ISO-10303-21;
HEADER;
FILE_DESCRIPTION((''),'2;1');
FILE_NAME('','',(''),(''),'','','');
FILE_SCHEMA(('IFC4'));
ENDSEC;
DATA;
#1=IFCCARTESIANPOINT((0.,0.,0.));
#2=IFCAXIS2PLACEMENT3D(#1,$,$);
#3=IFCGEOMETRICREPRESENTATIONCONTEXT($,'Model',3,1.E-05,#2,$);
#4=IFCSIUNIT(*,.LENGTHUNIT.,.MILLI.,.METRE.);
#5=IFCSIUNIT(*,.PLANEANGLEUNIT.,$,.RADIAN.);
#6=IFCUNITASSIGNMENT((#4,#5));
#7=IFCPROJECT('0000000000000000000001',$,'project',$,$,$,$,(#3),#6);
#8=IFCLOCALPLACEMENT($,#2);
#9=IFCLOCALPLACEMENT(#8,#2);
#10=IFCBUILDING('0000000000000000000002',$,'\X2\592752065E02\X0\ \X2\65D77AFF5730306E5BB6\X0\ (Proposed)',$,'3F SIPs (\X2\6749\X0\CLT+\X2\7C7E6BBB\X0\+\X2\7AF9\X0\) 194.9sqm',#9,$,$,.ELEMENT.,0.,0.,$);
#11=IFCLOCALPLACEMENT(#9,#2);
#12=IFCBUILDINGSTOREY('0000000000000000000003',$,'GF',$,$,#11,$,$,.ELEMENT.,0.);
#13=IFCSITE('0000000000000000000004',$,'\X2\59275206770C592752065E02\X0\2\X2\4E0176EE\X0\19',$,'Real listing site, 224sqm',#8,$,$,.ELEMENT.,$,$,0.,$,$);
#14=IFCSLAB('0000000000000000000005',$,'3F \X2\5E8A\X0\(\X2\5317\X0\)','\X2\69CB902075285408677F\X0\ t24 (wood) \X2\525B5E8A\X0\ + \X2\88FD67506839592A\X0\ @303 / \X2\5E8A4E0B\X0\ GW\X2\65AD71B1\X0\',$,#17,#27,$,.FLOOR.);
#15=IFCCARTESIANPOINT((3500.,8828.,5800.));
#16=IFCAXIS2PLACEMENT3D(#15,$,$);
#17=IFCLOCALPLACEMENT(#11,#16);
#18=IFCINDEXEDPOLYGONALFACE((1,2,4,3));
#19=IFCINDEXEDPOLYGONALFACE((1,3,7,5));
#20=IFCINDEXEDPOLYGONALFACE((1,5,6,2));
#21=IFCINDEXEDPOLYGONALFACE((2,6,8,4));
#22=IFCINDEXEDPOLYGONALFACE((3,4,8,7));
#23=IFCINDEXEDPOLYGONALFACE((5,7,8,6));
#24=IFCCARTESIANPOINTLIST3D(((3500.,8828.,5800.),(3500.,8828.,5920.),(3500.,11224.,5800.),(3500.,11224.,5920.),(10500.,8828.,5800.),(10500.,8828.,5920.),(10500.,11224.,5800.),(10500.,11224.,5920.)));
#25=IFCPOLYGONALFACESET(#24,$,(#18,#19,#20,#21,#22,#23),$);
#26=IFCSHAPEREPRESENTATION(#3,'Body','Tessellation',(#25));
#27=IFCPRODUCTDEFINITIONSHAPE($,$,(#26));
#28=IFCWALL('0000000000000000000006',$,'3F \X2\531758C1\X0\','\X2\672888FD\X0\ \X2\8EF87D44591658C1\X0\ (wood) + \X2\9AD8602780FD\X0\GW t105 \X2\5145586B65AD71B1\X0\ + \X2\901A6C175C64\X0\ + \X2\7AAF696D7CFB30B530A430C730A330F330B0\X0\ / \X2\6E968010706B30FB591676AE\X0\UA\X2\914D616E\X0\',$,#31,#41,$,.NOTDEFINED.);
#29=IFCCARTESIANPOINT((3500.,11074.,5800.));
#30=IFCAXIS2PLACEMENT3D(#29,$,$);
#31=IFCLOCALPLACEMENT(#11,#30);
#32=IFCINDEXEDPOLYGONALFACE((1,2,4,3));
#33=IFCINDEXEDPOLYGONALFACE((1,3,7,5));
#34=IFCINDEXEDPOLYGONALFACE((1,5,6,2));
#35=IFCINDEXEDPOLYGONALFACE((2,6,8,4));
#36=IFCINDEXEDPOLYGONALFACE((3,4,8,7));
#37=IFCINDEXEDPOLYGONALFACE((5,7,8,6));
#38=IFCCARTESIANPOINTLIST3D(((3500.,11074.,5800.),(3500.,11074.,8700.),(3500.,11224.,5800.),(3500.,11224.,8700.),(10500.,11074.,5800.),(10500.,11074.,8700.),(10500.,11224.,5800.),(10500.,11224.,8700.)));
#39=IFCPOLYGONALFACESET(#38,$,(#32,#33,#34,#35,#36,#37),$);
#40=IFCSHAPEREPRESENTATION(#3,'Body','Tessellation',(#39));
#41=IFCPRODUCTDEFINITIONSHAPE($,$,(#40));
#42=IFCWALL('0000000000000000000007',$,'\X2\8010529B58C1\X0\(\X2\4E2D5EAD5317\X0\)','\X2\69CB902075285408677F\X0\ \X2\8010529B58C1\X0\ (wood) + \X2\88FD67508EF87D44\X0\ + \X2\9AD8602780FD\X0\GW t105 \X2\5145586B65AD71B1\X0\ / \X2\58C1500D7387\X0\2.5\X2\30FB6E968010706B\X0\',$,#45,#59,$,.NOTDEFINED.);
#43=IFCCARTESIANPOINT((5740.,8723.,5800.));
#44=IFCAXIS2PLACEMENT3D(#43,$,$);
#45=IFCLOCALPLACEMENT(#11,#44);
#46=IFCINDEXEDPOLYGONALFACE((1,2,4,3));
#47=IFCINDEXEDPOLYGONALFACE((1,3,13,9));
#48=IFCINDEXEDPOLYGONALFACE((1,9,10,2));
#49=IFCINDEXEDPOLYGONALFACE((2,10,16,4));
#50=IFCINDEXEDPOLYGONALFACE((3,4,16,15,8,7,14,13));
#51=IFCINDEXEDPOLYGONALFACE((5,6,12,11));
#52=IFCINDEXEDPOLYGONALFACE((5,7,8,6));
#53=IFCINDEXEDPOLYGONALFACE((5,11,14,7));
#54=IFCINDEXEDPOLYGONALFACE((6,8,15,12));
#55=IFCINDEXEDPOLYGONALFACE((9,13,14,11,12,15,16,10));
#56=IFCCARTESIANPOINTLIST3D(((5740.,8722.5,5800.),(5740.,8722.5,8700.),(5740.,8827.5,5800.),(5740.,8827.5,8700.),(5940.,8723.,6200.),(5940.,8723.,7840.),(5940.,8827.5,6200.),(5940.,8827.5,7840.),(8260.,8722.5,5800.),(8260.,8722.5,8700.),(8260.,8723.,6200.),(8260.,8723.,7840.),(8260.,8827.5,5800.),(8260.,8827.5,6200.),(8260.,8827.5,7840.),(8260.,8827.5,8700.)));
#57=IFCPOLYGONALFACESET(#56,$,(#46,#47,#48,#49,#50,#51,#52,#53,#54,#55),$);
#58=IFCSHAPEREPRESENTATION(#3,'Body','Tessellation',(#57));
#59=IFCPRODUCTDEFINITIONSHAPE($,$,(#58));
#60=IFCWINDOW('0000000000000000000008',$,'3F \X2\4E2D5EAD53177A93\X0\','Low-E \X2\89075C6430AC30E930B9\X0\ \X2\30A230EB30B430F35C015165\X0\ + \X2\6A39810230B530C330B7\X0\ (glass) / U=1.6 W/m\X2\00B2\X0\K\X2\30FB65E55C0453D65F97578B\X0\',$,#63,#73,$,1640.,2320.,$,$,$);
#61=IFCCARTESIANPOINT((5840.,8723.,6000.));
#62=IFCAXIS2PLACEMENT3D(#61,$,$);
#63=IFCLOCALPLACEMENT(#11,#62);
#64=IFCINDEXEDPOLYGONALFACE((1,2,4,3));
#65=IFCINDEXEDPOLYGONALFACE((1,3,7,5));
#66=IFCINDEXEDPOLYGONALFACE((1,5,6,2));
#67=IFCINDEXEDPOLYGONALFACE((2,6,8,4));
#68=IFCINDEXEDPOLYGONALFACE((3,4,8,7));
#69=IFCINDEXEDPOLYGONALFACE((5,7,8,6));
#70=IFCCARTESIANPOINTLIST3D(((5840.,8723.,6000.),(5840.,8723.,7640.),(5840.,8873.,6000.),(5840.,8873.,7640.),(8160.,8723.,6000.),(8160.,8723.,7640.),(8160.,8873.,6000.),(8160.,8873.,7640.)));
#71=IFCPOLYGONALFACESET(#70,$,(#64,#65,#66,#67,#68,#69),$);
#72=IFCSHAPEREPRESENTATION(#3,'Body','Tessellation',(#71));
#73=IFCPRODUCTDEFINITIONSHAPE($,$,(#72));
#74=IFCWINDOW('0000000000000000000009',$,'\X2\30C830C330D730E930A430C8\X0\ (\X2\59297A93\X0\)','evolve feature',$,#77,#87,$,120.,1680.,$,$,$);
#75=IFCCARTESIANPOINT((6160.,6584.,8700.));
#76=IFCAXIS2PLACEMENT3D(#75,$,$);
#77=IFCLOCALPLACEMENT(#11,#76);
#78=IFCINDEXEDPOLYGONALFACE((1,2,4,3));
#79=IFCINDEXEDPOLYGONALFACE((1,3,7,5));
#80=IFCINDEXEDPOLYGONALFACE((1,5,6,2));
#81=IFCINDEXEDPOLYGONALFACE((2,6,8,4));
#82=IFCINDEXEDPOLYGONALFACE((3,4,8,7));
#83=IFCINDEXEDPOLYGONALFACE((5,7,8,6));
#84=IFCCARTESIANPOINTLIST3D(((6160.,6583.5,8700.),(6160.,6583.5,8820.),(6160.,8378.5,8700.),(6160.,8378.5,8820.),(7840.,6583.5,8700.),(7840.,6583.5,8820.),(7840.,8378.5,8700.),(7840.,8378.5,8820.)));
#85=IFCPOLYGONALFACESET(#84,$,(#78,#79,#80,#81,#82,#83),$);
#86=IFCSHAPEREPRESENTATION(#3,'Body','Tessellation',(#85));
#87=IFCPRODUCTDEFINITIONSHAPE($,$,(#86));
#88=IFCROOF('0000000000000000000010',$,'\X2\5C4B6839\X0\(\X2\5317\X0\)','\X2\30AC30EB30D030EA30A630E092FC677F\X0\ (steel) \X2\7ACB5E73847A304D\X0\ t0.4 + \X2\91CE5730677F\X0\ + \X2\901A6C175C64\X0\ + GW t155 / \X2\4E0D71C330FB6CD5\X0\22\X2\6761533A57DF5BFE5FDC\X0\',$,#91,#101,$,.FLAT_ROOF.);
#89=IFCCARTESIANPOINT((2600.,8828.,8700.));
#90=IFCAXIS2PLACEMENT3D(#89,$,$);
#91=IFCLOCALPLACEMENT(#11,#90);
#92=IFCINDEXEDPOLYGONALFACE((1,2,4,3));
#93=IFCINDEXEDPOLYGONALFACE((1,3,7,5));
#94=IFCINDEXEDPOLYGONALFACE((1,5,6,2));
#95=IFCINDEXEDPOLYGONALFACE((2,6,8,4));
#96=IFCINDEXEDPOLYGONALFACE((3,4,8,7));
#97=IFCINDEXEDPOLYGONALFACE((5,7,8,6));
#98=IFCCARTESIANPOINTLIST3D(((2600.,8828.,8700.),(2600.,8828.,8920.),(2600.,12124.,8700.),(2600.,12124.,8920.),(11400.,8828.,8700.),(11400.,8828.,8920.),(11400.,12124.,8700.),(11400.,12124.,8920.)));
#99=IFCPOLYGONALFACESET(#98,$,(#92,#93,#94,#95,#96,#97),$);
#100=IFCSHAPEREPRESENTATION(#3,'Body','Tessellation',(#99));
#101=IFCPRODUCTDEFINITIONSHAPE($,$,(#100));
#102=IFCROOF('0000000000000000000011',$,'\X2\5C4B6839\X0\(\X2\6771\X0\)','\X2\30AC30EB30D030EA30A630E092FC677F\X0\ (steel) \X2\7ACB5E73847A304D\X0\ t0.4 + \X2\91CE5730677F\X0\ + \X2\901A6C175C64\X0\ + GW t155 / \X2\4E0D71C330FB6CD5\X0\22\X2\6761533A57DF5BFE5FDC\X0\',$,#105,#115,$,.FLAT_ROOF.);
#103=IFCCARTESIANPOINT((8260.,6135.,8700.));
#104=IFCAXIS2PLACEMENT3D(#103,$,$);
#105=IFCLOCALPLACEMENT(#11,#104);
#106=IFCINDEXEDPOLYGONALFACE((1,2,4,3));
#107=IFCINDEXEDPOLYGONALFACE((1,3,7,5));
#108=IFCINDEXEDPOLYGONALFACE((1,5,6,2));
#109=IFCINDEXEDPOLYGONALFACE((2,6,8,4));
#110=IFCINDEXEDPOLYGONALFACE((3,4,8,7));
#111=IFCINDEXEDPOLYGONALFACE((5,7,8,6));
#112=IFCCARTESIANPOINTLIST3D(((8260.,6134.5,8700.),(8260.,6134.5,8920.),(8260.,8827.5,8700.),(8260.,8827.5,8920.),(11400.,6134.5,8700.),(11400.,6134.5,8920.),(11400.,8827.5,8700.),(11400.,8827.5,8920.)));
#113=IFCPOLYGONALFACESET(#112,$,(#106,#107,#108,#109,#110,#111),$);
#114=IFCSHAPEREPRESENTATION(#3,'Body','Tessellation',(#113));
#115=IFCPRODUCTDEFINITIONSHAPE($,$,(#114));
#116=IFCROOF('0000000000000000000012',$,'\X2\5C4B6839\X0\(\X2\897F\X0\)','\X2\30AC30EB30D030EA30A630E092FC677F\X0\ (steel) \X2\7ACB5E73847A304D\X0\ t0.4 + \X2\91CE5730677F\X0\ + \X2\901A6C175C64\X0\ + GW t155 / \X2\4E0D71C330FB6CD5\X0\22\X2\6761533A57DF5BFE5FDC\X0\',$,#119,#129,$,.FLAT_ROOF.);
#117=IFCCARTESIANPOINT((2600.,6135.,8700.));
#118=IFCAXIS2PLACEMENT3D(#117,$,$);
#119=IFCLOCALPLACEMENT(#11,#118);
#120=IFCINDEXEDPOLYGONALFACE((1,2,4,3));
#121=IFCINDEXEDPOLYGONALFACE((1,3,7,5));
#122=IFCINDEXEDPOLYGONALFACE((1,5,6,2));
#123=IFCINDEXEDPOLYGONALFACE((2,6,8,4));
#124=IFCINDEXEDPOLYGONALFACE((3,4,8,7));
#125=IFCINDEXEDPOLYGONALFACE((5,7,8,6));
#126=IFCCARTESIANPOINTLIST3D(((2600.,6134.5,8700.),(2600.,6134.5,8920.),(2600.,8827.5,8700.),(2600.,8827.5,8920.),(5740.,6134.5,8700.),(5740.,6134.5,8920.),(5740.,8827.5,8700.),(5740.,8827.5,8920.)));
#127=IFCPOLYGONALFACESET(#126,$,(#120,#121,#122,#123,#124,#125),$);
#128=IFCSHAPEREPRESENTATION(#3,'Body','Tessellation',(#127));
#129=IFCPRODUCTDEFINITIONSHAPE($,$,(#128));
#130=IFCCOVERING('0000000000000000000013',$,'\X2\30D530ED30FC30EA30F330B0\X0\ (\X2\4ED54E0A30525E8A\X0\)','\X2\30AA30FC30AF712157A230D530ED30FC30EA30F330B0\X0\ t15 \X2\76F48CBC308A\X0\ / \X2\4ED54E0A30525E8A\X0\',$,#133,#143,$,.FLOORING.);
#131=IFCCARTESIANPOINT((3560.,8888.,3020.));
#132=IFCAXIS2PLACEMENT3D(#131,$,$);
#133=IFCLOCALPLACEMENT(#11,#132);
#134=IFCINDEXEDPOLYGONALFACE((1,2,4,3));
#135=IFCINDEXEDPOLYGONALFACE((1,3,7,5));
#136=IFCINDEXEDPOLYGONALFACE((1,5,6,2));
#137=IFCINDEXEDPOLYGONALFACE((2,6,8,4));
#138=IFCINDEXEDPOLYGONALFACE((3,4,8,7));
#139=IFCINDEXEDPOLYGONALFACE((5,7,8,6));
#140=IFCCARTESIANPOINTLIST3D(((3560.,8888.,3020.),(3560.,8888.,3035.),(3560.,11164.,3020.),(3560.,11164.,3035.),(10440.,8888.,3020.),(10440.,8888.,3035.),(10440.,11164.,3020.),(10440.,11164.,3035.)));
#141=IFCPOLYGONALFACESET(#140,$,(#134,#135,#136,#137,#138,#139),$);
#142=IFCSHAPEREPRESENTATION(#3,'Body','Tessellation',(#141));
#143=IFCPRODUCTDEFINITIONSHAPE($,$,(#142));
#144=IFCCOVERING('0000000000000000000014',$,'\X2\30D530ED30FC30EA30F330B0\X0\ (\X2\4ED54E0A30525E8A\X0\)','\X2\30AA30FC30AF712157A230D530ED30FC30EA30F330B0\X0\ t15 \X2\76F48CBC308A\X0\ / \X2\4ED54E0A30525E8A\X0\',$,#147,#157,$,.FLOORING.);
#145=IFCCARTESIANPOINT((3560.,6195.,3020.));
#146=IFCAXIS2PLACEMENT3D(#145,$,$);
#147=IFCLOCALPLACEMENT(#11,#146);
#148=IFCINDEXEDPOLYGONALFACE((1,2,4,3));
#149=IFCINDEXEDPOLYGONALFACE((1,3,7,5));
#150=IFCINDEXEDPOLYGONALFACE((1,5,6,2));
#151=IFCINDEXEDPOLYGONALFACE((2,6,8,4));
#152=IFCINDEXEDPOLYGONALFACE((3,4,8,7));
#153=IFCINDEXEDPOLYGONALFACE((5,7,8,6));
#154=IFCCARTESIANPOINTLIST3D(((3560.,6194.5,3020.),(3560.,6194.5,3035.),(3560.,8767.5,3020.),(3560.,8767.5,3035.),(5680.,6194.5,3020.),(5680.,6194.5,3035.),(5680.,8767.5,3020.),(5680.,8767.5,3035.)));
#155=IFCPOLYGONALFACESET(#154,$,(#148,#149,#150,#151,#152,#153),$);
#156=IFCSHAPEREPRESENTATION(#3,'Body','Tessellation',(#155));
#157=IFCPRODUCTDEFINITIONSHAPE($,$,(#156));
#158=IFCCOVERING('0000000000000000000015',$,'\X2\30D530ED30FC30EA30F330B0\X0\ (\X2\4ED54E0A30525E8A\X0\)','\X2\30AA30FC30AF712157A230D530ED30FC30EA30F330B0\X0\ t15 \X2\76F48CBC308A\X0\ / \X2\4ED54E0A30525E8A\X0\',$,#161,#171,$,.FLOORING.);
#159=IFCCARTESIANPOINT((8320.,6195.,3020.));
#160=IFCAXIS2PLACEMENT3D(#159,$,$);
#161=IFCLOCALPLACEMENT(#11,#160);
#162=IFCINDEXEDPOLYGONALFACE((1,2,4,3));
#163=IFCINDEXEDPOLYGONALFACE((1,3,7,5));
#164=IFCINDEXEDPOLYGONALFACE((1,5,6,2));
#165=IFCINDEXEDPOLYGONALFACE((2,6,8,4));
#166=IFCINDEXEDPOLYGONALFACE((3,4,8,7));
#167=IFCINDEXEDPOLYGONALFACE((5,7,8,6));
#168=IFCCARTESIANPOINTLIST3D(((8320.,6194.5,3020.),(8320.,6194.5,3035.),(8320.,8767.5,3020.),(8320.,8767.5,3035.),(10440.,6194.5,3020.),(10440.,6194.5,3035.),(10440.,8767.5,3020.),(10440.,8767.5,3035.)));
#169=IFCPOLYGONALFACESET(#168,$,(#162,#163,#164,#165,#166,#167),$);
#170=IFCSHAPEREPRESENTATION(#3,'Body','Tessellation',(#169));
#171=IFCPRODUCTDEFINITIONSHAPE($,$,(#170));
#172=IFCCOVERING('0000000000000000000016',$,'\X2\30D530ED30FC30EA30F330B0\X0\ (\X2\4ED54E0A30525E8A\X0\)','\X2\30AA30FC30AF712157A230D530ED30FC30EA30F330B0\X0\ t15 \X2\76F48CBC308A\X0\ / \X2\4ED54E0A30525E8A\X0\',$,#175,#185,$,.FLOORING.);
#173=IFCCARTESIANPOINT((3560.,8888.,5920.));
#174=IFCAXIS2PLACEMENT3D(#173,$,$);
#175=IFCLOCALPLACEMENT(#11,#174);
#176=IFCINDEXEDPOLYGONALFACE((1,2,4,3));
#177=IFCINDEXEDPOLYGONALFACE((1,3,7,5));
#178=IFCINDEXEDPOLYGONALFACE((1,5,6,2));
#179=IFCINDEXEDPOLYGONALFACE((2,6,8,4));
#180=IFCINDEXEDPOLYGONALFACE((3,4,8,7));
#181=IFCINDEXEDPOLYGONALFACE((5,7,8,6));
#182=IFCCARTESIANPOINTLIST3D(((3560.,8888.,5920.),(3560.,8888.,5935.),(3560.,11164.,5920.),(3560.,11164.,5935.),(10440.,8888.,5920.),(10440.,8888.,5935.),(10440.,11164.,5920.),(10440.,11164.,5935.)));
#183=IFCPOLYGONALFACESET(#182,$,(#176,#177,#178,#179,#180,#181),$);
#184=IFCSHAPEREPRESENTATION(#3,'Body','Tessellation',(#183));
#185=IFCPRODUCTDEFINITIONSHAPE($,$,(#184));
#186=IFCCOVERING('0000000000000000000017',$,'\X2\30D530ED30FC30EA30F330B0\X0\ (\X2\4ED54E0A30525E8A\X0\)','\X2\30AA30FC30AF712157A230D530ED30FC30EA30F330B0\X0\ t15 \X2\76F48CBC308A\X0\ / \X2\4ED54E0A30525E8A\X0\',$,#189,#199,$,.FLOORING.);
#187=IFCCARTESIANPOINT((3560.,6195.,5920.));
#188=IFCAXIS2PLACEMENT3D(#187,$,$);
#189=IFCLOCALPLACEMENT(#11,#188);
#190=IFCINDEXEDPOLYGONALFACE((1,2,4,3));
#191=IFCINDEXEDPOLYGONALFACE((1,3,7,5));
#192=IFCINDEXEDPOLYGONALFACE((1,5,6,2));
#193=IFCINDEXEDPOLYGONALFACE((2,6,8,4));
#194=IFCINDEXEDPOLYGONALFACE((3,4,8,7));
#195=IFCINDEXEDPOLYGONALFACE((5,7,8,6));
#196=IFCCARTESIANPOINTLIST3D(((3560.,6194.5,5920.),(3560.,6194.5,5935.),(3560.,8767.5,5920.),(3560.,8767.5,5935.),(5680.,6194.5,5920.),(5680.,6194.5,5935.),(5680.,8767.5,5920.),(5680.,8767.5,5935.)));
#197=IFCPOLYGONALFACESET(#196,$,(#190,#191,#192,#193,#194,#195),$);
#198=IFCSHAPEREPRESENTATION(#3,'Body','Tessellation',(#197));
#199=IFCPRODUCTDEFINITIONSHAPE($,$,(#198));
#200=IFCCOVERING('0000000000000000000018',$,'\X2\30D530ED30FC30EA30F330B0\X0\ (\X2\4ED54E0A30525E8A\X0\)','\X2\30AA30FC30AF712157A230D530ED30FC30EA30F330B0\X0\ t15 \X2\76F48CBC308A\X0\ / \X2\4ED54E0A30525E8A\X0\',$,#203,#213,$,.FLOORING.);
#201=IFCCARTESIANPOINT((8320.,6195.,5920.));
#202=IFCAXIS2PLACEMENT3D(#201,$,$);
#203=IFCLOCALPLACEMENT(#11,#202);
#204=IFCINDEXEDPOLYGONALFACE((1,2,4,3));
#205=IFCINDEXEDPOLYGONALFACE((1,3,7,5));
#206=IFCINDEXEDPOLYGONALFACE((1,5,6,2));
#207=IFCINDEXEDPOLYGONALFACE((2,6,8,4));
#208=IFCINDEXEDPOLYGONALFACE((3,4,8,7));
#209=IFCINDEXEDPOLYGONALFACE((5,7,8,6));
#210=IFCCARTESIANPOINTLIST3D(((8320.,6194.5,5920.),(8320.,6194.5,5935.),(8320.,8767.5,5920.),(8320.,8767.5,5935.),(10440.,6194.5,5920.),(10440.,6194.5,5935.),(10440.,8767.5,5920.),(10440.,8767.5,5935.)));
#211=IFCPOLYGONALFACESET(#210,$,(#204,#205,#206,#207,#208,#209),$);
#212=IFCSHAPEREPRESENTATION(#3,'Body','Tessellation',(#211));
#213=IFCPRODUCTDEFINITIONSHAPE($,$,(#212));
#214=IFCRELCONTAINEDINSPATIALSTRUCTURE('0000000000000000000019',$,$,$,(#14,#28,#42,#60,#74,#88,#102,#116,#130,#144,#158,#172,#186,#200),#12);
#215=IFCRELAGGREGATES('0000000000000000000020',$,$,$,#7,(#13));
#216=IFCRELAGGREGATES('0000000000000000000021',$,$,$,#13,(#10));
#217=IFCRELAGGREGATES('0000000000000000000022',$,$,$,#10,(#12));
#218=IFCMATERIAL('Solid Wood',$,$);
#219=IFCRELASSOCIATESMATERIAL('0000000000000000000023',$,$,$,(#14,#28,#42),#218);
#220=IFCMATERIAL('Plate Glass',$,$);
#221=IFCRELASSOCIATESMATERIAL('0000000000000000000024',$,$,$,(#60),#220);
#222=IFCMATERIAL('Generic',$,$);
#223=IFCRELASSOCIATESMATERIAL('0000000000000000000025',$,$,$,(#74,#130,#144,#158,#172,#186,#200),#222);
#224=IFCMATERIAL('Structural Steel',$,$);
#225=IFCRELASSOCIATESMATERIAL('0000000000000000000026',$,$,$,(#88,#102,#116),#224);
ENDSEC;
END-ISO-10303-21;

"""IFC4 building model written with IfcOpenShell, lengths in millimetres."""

from ifc_helpers import new_model, si_unit, frame, frame_2d, origin, place, context, project, spatial, rectangle, extrude, material, element, fill, save


model = new_model("IFC4")

# Units and contexts
model_context = context("Model", 3, precision=1e-05, world=origin())
ifc_project = project(units=[si_unit("LENGTHUNIT", "METRE", prefix="MILLI"), si_unit("PLANEANGLEUNIT", "RADIAN")], contexts=[model_context])

# Site, building, storey
site_placement = place(None, origin())
site = spatial("IfcSite", under=ifc_project, at=site_placement, Name="大分県大分市2丁目19", ObjectType="Real listing site, 224sqm", CompositionType="ELEMENT", RefElevation=0.0)
building_placement = place(site_placement, origin())
building = spatial("IfcBuilding", under=site, at=building_placement, Name="大分市 旗竿地の家 (Proposed)", ObjectType="3F SIPs (杉CLT+籾殻+竹) 194.9sqm", CompositionType="ELEMENT", ElevationOfRefHeight=0.0, ElevationOfTerrain=0.0)
storey_placement = place(building_placement, origin())
storey = spatial("IfcBuildingStorey", under=building, at=storey_placement, Name="GF", CompositionType="ELEMENT", Elevation=0.0)

# Slab
ifc_material_1 = material(Name="Solid Wood")
slab_placement = place(storey_placement, frame((3500.0, 8828.0, 5800.0)))
element("IfcSlab", 1, at=slab_placement, inside=storey, material=ifc_material_1, Name="3F 床(北)", Description="構造用合板 t24 (wood) 剛床 + 製材根太 @303 / 床下 GW断熱", PredefinedType="FLOOR", context=model_context, shape_type="SweptSolid", body=[
    extrude(rectangle(XDim=7000.0, YDim=2396.0, at=frame_2d((3500.0, 1198.0))), frame((3500.0, 8828.0, 5800.0)), (0.0, 0.0, 1.0), 120.0),
])

# Wall
wall_1_placement = place(storey_placement, frame((3500.0, 11074.0, 5800.0)))
element("IfcWall", 2, at=wall_1_placement, inside=storey, material=ifc_material_1, Name="3F 北壁", Description="木製 軸組外壁 (wood) + 高性能GW t105 充填断熱 + 通気層 + 窯業系サイディング / 準耐火・外皮UA配慮", PredefinedType="NOTDEFINED", context=model_context, shape_type="SweptSolid", body=[
    extrude(rectangle(XDim=7000.0, YDim=150.0, at=frame_2d((3500.0, 75.0))), frame((3500.0, 11074.0, 5800.0)), (0.0, 0.0, 1.0), 2900.0),
])

# Wall, opening, window
wall_2_placement = place(storey_placement, frame((5740.0, 8723.0, 5800.0)))
wall_2 = element("IfcWall", 3, at=wall_2_placement, inside=storey, material=ifc_material_1, Name="耐力壁(中庭北)", Description="構造用合板 耐力壁 (wood) + 製材軸組 + 高性能GW t105 充填断熱 / 壁倍率2.5・準耐火", PredefinedType="NOTDEFINED", context=model_context, shape_type="SweptSolid", body=[
    extrude(rectangle(XDim=2520.0, YDim=105.0, at=frame_2d((1260.0, 52.0))), frame((5740.0, 8723.0, 5800.0)), (0.0, 0.0, 1.0), 2900.0),
])
opening_placement = place(storey_placement, frame((5840.0, 8723.0, 6000.0)))
opening = element("IfcOpeningElement", 4, at=opening_placement, cuts=wall_2, PredefinedType="NOTDEFINED", context=model_context, shape_type="SweptSolid", body=[
    extrude(rectangle(XDim=2320.0, YDim=150.0, at=frame_2d((1160.0, 75.0))), frame((5840.0, 8723.0, 6000.0)), (0.0, 0.0, 1.0), 1640.0),
])
ifc_material_2 = material(Name="Plate Glass")
window_1_placement = place(storey_placement, frame((5840.0, 8723.0, 6000.0)))
window_1 = element("IfcWindow", 5, at=window_1_placement, inside=storey, material=ifc_material_2, Name="3F 中庭北窓", Description="Low-E 複層ガラス アルゴン封入 + 樹脂サッシ (glass) / U=1.6 W/m²K・日射取得型", OverallHeight=1640.0, OverallWidth=2320.0, context=model_context, shape_type="SweptSolid", body=[
    extrude(rectangle(XDim=2320.0, YDim=150.0, at=frame_2d((1160.0, 75.0))), frame((5840.0, 8723.0, 6000.0)), (0.0, 0.0, 1.0), 1640.0),
])
fill(opening, window_1)

# Window
ifc_material_3 = material(Name="Generic")
window_2_placement = place(storey_placement, frame((6160.0, 6584.0, 8700.0)))
element("IfcWindow", 6, at=window_2_placement, inside=storey, material=ifc_material_3, Name="トップライト (天窓)", Description="evolve feature", OverallHeight=120.0, OverallWidth=1680.0, context=model_context, shape_type="SweptSolid", body=[
    extrude(rectangle(XDim=1680.0, YDim=1795.0, at=frame_2d((840.0, 897.0))), frame((6160.0, 6584.0, 8700.0)), (0.0, 0.0, 1.0), 120.0),
])

# Roofs
ifc_material_4 = material(Name="Structural Steel")
roof_1_placement = place(storey_placement, frame((2600.0, 8828.0, 8700.0)))
element("IfcRoof", 7, at=roof_1_placement, inside=storey, material=ifc_material_4, Name="屋根(北)", Description="ガルバリウム鋼板 (steel) 立平葺き t0.4 + 野地板 + 通気層 + GW t155 / 不燃・法22条区域対応", PredefinedType="FLAT_ROOF", context=model_context, shape_type="SweptSolid", body=[
    extrude(rectangle(XDim=8800.0, YDim=3296.0, at=frame_2d((4400.0, 1648.0))), frame((2600.0, 8828.0, 8700.0)), (0.0, 0.0, 1.0), 220.0),
])
roof_2_placement = place(storey_placement, frame((8260.0, 6135.0, 8700.0)))
element("IfcRoof", 8, at=roof_2_placement, inside=storey, material=ifc_material_4, Name="屋根(東)", Description="ガルバリウム鋼板 (steel) 立平葺き t0.4 + 野地板 + 通気層 + GW t155 / 不燃・法22条区域対応", PredefinedType="FLAT_ROOF", context=model_context, shape_type="SweptSolid", body=[
    extrude(rectangle(XDim=3140.0, YDim=2693.0, at=frame_2d((1570.0, 1346.0))), frame((8260.0, 6135.0, 8700.0)), (0.0, 0.0, 1.0), 220.0),
])
roof_3_placement = place(storey_placement, frame((2600.0, 6135.0, 8700.0)))
element("IfcRoof", 9, at=roof_3_placement, inside=storey, material=ifc_material_4, Name="屋根(西)", Description="ガルバリウム鋼板 (steel) 立平葺き t0.4 + 野地板 + 通気層 + GW t155 / 不燃・法22条区域対応", PredefinedType="FLAT_ROOF", context=model_context, shape_type="SweptSolid", body=[
    extrude(rectangle(XDim=3140.0, YDim=2693.0, at=frame_2d((1570.0, 1346.0))), frame((2600.0, 6135.0, 8700.0)), (0.0, 0.0, 1.0), 220.0),
])

# Coverings
covering_1_placement = place(storey_placement, frame((3560.0, 8888.0, 3020.0)))
element("IfcCovering", 10, at=covering_1_placement, inside=storey, material=ifc_material_3, Name="フローリング (仕上げ床)", Description="オーク無垢フローリング t15 直貼り / 仕上げ床", PredefinedType="FLOORING", context=model_context, shape_type="SweptSolid", body=[
    extrude(rectangle(XDim=6880.0, YDim=2276.0, at=frame_2d((3440.0, 1138.0))), frame((3560.0, 8888.0, 3020.0)), (0.0, 0.0, 1.0), 15.0),
])
covering_2_placement = place(storey_placement, frame((3560.0, 6195.0, 3020.0)))
element("IfcCovering", 11, at=covering_2_placement, inside=storey, material=ifc_material_3, Name="フローリング (仕上げ床)", Description="オーク無垢フローリング t15 直貼り / 仕上げ床", PredefinedType="FLOORING", context=model_context, shape_type="SweptSolid", body=[
    extrude(rectangle(XDim=2120.0, YDim=2573.0, at=frame_2d((1060.0, 1286.0))), frame((3560.0, 6195.0, 3020.0)), (0.0, 0.0, 1.0), 15.0),
])
covering_3_placement = place(storey_placement, frame((8320.0, 6195.0, 3020.0)))
element("IfcCovering", 12, at=covering_3_placement, inside=storey, material=ifc_material_3, Name="フローリング (仕上げ床)", Description="オーク無垢フローリング t15 直貼り / 仕上げ床", PredefinedType="FLOORING", context=model_context, shape_type="SweptSolid", body=[
    extrude(rectangle(XDim=2120.0, YDim=2573.0, at=frame_2d((1060.0, 1286.0))), frame((8320.0, 6195.0, 3020.0)), (0.0, 0.0, 1.0), 15.0),
])
covering_4_placement = place(storey_placement, frame((3560.0, 8888.0, 5920.0)))
element("IfcCovering", 13, at=covering_4_placement, inside=storey, material=ifc_material_3, Name="フローリング (仕上げ床)", Description="オーク無垢フローリング t15 直貼り / 仕上げ床", PredefinedType="FLOORING", context=model_context, shape_type="SweptSolid", body=[
    extrude(rectangle(XDim=6880.0, YDim=2276.0, at=frame_2d((3440.0, 1138.0))), frame((3560.0, 8888.0, 5920.0)), (0.0, 0.0, 1.0), 15.0),
])
covering_5_placement = place(storey_placement, frame((3560.0, 6195.0, 5920.0)))
element("IfcCovering", 14, at=covering_5_placement, inside=storey, material=ifc_material_3, Name="フローリング (仕上げ床)", Description="オーク無垢フローリング t15 直貼り / 仕上げ床", PredefinedType="FLOORING", context=model_context, shape_type="SweptSolid", body=[
    extrude(rectangle(XDim=2120.0, YDim=2573.0, at=frame_2d((1060.0, 1286.0))), frame((3560.0, 6195.0, 5920.0)), (0.0, 0.0, 1.0), 15.0),
])
covering_6_placement = place(storey_placement, frame((8320.0, 6195.0, 5920.0)))
element("IfcCovering", 15, at=covering_6_placement, inside=storey, material=ifc_material_3, Name="フローリング (仕上げ床)", Description="オーク無垢フローリング t15 直貼り / 仕上げ床", PredefinedType="FLOORING", context=model_context, shape_type="SweptSolid", body=[
    extrude(rectangle(XDim=2120.0, YDim=2573.0, at=frame_2d((1060.0, 1286.0))), frame((8320.0, 6195.0, 5920.0)), (0.0, 0.0, 1.0), 15.0),
])

save(model, "model.ifc")
